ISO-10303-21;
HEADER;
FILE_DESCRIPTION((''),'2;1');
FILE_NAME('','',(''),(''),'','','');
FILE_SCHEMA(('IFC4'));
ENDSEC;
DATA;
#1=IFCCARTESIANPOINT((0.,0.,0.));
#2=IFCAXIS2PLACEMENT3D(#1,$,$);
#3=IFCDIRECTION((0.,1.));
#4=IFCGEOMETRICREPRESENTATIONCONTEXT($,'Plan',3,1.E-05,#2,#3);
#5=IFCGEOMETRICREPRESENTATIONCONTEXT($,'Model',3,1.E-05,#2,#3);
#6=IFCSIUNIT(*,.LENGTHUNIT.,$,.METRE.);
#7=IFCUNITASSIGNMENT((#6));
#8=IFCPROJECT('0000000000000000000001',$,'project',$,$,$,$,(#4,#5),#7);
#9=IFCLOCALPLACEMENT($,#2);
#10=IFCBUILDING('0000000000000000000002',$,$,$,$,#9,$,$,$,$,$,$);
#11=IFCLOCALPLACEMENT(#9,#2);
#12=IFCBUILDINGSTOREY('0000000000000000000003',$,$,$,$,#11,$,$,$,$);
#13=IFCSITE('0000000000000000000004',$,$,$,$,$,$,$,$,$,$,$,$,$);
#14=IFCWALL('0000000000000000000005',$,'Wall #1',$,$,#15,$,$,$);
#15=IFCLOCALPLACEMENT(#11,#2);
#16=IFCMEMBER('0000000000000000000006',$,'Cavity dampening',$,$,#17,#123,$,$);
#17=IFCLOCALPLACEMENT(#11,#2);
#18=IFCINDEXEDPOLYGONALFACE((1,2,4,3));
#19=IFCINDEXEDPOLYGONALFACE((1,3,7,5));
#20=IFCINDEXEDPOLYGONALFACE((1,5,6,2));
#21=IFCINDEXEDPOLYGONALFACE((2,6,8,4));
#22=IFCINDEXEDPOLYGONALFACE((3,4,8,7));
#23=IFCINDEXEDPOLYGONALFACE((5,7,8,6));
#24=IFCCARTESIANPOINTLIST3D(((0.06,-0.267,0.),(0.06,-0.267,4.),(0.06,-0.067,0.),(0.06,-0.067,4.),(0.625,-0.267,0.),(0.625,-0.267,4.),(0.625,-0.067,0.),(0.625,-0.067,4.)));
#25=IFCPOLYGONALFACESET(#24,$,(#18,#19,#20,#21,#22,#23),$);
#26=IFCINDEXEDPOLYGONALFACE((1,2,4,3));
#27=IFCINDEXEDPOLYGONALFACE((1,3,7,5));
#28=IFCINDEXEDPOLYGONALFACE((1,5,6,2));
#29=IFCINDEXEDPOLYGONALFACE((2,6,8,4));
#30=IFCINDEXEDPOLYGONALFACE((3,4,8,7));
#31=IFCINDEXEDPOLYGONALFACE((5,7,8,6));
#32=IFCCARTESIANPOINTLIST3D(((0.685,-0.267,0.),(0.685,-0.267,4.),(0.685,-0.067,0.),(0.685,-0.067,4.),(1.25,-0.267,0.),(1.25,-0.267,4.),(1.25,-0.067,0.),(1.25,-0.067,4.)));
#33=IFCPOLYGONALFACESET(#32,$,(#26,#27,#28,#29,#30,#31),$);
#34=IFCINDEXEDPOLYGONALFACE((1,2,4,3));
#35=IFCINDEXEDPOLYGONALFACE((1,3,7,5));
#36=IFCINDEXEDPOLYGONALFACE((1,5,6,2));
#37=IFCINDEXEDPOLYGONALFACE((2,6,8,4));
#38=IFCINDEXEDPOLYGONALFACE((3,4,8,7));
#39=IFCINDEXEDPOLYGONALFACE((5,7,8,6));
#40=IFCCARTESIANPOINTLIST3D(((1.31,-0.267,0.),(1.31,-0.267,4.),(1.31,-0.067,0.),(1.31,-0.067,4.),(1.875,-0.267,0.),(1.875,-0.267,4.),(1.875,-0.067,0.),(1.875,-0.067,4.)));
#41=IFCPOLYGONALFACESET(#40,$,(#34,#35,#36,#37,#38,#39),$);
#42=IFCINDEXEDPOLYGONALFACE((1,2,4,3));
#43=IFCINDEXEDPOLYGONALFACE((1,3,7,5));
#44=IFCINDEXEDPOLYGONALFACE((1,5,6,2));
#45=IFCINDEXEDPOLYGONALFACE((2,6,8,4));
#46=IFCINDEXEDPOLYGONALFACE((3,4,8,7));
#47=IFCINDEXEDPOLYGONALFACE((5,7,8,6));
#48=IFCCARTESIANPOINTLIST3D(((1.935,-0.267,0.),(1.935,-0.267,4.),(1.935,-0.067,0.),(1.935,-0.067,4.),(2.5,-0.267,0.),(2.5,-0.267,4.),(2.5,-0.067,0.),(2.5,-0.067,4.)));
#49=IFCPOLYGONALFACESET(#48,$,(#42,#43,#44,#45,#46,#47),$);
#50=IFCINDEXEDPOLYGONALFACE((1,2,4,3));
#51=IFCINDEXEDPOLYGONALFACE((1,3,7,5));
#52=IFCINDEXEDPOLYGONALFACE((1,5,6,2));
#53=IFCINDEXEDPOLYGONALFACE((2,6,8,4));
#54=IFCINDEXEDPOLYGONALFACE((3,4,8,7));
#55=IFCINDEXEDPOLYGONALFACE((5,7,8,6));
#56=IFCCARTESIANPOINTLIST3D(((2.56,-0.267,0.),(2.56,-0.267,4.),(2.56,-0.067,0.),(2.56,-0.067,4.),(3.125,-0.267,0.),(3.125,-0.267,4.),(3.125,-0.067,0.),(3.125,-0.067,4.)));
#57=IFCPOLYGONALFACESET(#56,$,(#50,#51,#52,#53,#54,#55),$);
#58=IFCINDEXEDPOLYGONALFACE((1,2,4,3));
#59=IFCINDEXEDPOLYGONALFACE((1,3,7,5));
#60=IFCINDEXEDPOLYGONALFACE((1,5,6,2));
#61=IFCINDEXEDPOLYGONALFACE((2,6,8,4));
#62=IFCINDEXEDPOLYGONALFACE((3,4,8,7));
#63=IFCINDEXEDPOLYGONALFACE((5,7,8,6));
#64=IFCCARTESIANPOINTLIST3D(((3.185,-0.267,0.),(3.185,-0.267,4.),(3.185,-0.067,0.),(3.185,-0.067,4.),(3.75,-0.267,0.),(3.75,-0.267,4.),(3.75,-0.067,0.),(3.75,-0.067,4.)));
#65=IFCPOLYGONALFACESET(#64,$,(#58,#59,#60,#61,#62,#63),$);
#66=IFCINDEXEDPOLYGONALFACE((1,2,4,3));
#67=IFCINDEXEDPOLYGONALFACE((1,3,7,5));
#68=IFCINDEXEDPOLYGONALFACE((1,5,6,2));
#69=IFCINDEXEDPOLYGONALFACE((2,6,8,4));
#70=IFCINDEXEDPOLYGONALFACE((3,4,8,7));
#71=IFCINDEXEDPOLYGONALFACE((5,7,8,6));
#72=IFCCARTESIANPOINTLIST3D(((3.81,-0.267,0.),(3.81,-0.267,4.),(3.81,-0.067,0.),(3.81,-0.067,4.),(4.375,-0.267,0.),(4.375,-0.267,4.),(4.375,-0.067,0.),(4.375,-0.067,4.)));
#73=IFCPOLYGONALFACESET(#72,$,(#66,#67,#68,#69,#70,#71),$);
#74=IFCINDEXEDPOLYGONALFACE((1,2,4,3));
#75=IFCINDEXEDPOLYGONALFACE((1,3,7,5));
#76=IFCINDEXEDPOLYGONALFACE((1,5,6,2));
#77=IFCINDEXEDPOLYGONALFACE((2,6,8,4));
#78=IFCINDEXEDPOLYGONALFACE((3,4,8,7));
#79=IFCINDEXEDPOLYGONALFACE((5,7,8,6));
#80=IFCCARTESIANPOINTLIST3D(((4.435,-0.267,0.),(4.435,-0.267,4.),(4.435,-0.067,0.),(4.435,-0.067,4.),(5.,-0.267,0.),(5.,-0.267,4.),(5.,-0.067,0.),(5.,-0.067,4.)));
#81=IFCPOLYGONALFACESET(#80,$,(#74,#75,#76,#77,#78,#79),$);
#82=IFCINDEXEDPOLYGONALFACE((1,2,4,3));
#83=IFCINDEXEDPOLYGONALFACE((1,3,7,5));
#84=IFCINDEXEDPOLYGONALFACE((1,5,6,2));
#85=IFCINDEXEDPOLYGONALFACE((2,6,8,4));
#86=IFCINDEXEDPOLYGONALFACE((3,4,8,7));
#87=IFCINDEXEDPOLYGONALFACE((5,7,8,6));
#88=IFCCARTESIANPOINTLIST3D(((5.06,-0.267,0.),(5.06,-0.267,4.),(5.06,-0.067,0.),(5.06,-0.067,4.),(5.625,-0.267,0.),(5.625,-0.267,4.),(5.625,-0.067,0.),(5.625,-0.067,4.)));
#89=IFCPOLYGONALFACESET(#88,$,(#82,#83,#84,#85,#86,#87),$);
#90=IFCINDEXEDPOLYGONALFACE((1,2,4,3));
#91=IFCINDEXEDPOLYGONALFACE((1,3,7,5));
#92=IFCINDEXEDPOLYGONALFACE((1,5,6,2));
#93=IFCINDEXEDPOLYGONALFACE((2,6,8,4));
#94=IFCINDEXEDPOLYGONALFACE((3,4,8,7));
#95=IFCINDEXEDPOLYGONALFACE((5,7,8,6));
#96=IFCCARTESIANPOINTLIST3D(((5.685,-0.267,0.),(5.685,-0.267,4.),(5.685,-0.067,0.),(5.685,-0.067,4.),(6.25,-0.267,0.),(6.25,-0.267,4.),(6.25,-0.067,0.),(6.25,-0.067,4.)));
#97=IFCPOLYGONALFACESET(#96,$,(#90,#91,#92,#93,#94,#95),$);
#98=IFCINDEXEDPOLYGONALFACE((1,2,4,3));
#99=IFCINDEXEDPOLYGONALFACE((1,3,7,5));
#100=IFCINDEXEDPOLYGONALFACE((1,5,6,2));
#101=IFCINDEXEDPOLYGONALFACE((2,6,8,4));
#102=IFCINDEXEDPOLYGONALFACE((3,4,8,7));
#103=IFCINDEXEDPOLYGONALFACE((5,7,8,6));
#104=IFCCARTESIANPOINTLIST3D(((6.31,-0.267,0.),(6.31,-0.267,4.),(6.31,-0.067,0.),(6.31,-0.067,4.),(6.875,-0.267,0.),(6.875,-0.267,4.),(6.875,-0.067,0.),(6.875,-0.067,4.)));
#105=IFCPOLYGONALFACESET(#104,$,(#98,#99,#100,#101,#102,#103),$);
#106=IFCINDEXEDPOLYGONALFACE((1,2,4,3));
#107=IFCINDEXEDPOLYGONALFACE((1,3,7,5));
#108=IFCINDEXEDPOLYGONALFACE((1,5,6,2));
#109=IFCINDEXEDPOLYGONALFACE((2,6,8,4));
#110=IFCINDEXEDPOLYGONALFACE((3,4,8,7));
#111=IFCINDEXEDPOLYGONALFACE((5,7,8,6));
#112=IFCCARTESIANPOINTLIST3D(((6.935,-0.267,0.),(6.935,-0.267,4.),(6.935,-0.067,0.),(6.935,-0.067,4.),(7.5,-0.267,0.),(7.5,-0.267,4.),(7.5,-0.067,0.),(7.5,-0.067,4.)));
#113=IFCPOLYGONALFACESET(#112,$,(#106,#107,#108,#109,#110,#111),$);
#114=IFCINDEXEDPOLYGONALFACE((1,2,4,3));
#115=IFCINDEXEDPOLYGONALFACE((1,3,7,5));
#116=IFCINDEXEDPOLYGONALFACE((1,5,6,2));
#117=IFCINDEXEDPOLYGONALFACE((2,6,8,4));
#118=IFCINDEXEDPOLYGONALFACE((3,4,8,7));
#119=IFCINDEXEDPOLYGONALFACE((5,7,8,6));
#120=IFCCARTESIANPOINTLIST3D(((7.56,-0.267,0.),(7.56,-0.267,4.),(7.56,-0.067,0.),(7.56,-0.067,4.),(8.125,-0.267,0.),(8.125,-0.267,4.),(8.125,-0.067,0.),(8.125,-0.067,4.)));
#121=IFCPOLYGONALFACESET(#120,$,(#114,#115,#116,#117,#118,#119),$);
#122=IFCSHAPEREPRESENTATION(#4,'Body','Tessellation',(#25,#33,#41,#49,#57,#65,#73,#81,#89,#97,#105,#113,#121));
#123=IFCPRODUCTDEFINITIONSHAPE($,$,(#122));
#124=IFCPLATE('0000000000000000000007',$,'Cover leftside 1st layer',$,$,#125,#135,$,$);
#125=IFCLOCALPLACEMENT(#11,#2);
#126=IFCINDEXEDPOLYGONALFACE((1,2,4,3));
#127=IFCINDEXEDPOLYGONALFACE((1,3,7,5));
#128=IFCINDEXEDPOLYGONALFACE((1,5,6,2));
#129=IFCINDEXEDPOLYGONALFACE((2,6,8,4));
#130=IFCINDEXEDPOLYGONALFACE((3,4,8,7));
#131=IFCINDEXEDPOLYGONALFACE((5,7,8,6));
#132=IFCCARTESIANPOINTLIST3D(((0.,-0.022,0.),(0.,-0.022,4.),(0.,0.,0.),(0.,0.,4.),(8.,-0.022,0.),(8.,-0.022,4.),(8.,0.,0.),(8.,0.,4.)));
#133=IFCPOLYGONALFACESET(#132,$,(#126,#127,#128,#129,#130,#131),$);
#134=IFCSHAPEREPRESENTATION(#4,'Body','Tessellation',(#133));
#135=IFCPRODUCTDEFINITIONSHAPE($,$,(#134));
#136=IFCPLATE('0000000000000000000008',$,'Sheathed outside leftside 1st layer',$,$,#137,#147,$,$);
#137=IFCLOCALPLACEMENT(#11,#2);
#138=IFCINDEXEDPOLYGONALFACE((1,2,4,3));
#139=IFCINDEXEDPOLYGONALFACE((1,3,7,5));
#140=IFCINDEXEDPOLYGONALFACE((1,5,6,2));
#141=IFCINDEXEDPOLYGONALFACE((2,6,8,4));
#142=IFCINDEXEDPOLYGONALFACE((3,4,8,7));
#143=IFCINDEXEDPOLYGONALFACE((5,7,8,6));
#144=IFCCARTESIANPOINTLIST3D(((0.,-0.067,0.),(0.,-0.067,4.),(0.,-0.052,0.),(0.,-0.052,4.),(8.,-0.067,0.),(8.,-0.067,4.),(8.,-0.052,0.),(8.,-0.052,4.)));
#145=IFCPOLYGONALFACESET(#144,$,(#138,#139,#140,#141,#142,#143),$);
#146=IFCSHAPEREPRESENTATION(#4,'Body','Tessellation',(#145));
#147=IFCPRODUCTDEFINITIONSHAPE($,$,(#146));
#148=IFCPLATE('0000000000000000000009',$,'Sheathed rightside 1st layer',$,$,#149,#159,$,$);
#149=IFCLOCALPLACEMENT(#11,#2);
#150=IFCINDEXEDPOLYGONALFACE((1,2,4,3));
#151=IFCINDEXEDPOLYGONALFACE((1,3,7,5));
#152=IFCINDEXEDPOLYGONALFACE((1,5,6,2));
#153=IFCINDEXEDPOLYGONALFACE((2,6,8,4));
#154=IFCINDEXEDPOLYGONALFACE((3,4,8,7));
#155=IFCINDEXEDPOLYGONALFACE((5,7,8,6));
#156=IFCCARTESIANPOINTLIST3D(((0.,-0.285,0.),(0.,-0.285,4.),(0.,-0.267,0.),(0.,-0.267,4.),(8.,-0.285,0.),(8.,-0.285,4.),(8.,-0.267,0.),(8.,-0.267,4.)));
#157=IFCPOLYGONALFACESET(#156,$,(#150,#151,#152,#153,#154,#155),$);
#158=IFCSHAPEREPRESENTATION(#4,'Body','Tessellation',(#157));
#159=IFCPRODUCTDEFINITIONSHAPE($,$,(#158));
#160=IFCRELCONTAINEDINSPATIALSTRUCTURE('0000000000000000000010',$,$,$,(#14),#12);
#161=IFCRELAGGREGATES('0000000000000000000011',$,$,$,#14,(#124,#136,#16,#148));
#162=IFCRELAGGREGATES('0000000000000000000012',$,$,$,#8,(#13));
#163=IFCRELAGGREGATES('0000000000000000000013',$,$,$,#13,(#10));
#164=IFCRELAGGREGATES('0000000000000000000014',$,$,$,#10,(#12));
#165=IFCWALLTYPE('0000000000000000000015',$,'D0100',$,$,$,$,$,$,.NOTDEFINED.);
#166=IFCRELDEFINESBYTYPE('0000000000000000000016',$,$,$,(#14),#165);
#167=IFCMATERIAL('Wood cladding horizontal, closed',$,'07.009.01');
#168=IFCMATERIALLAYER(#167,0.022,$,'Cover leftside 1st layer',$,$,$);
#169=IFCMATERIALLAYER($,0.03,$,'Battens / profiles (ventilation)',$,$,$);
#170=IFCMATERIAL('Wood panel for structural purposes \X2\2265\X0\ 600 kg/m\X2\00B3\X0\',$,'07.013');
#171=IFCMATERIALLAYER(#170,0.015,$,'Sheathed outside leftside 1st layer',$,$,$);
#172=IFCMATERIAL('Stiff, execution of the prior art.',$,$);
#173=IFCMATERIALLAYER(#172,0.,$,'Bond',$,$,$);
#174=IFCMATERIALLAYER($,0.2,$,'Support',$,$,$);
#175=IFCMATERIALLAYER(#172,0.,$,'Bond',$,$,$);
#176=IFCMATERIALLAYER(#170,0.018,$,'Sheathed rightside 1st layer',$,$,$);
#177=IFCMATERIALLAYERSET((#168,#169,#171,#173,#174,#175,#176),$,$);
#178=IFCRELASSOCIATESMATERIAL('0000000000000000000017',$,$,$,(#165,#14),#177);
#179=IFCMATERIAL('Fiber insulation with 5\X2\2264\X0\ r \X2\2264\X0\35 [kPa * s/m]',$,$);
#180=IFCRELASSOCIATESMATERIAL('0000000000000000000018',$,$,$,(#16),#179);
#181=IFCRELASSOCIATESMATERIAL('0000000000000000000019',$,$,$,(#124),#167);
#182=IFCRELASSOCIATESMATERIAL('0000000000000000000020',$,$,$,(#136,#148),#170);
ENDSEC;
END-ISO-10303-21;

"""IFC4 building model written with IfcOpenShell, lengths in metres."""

from ifc_helpers import new_model, si_unit, direction, frame, frame_2d, origin, origin_with_axes, place, context, project, spatial, rectangle, extrude, material, layer, layer_set, type_object, element, aggregate, save


model = new_model("IFC4")

# Units and contexts
plan_context = context("Plan", 3, precision=1e-05, world=origin(), true_north=direction((0.0, 1.0)))
model_context = context("Model", 3, precision=1e-05, world=origin(), true_north=direction((0.0, 1.0)))
ifc_project = project(units=[si_unit("LENGTHUNIT", "METRE")], contexts=[plan_context, model_context])

# Site, building, storey
site = spatial("IfcSite", under=ifc_project)
building_placement = place(None, origin())
building = spatial("IfcBuilding", under=site, at=building_placement)
storey_placement = place(building_placement, origin())
storey = spatial("IfcBuildingStorey", under=building, at=storey_placement)

# Wall, member, plates
ifc_material_1 = material(Name="Wood cladding horizontal, closed", Category="07.009.01")
ifc_layer_1 = layer(ifc_material_1, 0.022, Name="Cover leftside 1st layer")
ifc_layer_2 = layer(None, 0.03, Name="Battens / profiles (ventilation)")
ifc_material_2 = material(Name="Wood panel for structural purposes ≥ 600 kg/m³", Category="07.013")
ifc_layer_3 = layer(ifc_material_2, 0.015, Name="Sheathed outside leftside 1st layer")
ifc_material_3 = material(Name="Stiff, execution of the prior art.")
ifc_layer_4 = layer(ifc_material_3, 0.0, Name="Bond")
ifc_layer_5 = layer(None, 0.2, Name="Support")
ifc_layer_6 = layer(ifc_material_3, 0.0, Name="Bond")
ifc_layer_7 = layer(ifc_material_2, 0.018, Name="Sheathed rightside 1st layer")
ifc_layer_set = layer_set([ifc_layer_1, ifc_layer_2, ifc_layer_3, ifc_layer_4, ifc_layer_5, ifc_layer_6, ifc_layer_7])
wall_type = type_object("IfcWallType", Name="D0100", PredefinedType="NOTDEFINED", material=ifc_layer_set)
wall_placement = place(None, frame((0.0, 0.0, 0.0), z_axis=(0.0, -1.0, 0.0), x_axis=(1.0, 0.0, 0.0)))
wall = element("IfcWall", 1, at=wall_placement, inside=storey, type_object=wall_type, material=ifc_layer_set, Name="Wall #1")
ifc_material_4 = material(Name="Fiber insulation with 5≤ r ≤35 [kPa * s/m]")
member_1_placement = place(wall_placement, origin())
member_1 = element("IfcMember", 2, at=member_1_placement, material=ifc_material_4, Name="Cavity dampening", context=plan_context, shape_type="SweptSolid", body=[
    extrude(rectangle(XDim=0.565, YDim=0.2, at=frame_2d((0.2825, 0.1), x_axis=(1.0, 0.0))), frame((0.06, 4.0, 0.067), z_axis=(0.0, -1.0, 0.0), x_axis=(1.0, 0.0, 0.0)), (0.0, 0.0, 1.0), 4.0),
    extrude(rectangle(XDim=0.565, YDim=0.2, at=frame_2d((0.2825, 0.1), x_axis=(1.0, 0.0))), frame((0.685, 4.0, 0.067), z_axis=(0.0, -1.0, 0.0), x_axis=(1.0, 0.0, 0.0)), (0.0, 0.0, 1.0), 4.0),
    extrude(rectangle(XDim=0.565, YDim=0.2, at=frame_2d((0.2825, 0.1), x_axis=(1.0, 0.0))), frame((1.31, 4.0, 0.067), z_axis=(0.0, -1.0, 0.0), x_axis=(1.0, 0.0, 0.0)), (0.0, 0.0, 1.0), 4.0),
    extrude(rectangle(XDim=0.565, YDim=0.2, at=frame_2d((0.2825, 0.1), x_axis=(1.0, 0.0))), frame((1.935, 4.0, 0.067), z_axis=(0.0, -1.0, 0.0), x_axis=(1.0, 0.0, 0.0)), (0.0, 0.0, 1.0), 4.0),
    extrude(rectangle(XDim=0.565, YDim=0.2, at=frame_2d((0.2825, 0.1), x_axis=(1.0, 0.0))), frame((2.56, 4.0, 0.067), z_axis=(0.0, -1.0, 0.0), x_axis=(1.0, 0.0, 0.0)), (0.0, 0.0, 1.0), 4.0),
    extrude(rectangle(XDim=0.565, YDim=0.2, at=frame_2d((0.2825, 0.1), x_axis=(1.0, 0.0))), frame((3.185, 4.0, 0.067), z_axis=(0.0, -1.0, 0.0), x_axis=(1.0, 0.0, 0.0)), (0.0, 0.0, 1.0), 4.0),
    extrude(rectangle(XDim=0.565, YDim=0.2, at=frame_2d((0.2825, 0.1), x_axis=(1.0, 0.0))), frame((3.81, 4.0, 0.067), z_axis=(0.0, -1.0, 0.0), x_axis=(1.0, 0.0, 0.0)), (0.0, 0.0, 1.0), 4.0),
    extrude(rectangle(XDim=0.565, YDim=0.2, at=frame_2d((0.2825, 0.1), x_axis=(1.0, 0.0))), frame((4.435, 4.0, 0.067), z_axis=(0.0, -1.0, 0.0), x_axis=(1.0, 0.0, 0.0)), (0.0, 0.0, 1.0), 4.0),
    extrude(rectangle(XDim=0.565, YDim=0.2, at=frame_2d((0.2825, 0.1), x_axis=(1.0, 0.0))), frame((5.06, 4.0, 0.067), z_axis=(0.0, -1.0, 0.0), x_axis=(1.0, 0.0, 0.0)), (0.0, 0.0, 1.0), 4.0),
    extrude(rectangle(XDim=0.565, YDim=0.2, at=frame_2d((0.2825, 0.1), x_axis=(1.0, 0.0))), frame((5.685, 4.0, 0.067), z_axis=(0.0, -1.0, 0.0), x_axis=(1.0, 0.0, 0.0)), (0.0, 0.0, 1.0), 4.0),
    extrude(rectangle(XDim=0.565, YDim=0.2, at=frame_2d((0.2825, 0.1), x_axis=(1.0, 0.0))), frame((6.31, 4.0, 0.067), z_axis=(0.0, -1.0, 0.0), x_axis=(1.0, 0.0, 0.0)), (0.0, 0.0, 1.0), 4.0),
    extrude(rectangle(XDim=0.565, YDim=0.2, at=frame_2d((0.2825, 0.1), x_axis=(1.0, 0.0))), frame((6.935, 4.0, 0.067), z_axis=(0.0, -1.0, 0.0), x_axis=(1.0, 0.0, 0.0)), (0.0, 0.0, 1.0), 4.0),
    extrude(rectangle(XDim=0.565, YDim=0.2, at=frame_2d((0.2825, 0.1), x_axis=(1.0, 0.0))), frame((7.56, 4.0, 0.067), z_axis=(0.0, -1.0, 0.0), x_axis=(1.0, 0.0, 0.0)), (0.0, 0.0, 1.0), 4.0),
])
plate_1_placement = place(wall_placement, origin())
plate_1 = element("IfcPlate", 3, at=plate_1_placement, material=ifc_material_1, Name="Cover leftside 1st layer", context=plan_context, shape_type="SweptSolid", body=[
    extrude(rectangle(XDim=8.0, YDim=4.0, at=frame_2d((4.0, 2.0), x_axis=(1.0, 0.0))), origin_with_axes(), (0.0, 0.0, 1.0), 0.022),
])
plate_2_placement = place(wall_placement, origin())
plate_2 = element("IfcPlate", 4, at=plate_2_placement, material=ifc_material_2, Name="Sheathed outside leftside 1st layer", context=plan_context, shape_type="SweptSolid", body=[
    extrude(rectangle(XDim=8.0, YDim=4.0, at=frame_2d((4.0, 2.0), x_axis=(1.0, 0.0))), frame((0.0, 0.0, 0.052), z_axis=(0.0, 0.0, 1.0), x_axis=(1.0, 0.0, 0.0)), (0.0, 0.0, 1.0), 0.015),
])
plate_3_placement = place(wall_placement, origin())
plate_3 = element("IfcPlate", 5, at=plate_3_placement, material=ifc_material_2, Name="Sheathed rightside 1st layer", context=plan_context, shape_type="SweptSolid", body=[
    extrude(rectangle(XDim=8.0, YDim=4.0, at=frame_2d((4.0, 2.0), x_axis=(1.0, 0.0))), frame((0.0, 0.0, 0.267), z_axis=(0.0, 0.0, 1.0), x_axis=(1.0, 0.0, 0.0)), (0.0, 0.0, 1.0), 0.018),
])
aggregate(wall, [plate_1, plate_2, member_1, plate_3])

save(model, "model.ifc")
